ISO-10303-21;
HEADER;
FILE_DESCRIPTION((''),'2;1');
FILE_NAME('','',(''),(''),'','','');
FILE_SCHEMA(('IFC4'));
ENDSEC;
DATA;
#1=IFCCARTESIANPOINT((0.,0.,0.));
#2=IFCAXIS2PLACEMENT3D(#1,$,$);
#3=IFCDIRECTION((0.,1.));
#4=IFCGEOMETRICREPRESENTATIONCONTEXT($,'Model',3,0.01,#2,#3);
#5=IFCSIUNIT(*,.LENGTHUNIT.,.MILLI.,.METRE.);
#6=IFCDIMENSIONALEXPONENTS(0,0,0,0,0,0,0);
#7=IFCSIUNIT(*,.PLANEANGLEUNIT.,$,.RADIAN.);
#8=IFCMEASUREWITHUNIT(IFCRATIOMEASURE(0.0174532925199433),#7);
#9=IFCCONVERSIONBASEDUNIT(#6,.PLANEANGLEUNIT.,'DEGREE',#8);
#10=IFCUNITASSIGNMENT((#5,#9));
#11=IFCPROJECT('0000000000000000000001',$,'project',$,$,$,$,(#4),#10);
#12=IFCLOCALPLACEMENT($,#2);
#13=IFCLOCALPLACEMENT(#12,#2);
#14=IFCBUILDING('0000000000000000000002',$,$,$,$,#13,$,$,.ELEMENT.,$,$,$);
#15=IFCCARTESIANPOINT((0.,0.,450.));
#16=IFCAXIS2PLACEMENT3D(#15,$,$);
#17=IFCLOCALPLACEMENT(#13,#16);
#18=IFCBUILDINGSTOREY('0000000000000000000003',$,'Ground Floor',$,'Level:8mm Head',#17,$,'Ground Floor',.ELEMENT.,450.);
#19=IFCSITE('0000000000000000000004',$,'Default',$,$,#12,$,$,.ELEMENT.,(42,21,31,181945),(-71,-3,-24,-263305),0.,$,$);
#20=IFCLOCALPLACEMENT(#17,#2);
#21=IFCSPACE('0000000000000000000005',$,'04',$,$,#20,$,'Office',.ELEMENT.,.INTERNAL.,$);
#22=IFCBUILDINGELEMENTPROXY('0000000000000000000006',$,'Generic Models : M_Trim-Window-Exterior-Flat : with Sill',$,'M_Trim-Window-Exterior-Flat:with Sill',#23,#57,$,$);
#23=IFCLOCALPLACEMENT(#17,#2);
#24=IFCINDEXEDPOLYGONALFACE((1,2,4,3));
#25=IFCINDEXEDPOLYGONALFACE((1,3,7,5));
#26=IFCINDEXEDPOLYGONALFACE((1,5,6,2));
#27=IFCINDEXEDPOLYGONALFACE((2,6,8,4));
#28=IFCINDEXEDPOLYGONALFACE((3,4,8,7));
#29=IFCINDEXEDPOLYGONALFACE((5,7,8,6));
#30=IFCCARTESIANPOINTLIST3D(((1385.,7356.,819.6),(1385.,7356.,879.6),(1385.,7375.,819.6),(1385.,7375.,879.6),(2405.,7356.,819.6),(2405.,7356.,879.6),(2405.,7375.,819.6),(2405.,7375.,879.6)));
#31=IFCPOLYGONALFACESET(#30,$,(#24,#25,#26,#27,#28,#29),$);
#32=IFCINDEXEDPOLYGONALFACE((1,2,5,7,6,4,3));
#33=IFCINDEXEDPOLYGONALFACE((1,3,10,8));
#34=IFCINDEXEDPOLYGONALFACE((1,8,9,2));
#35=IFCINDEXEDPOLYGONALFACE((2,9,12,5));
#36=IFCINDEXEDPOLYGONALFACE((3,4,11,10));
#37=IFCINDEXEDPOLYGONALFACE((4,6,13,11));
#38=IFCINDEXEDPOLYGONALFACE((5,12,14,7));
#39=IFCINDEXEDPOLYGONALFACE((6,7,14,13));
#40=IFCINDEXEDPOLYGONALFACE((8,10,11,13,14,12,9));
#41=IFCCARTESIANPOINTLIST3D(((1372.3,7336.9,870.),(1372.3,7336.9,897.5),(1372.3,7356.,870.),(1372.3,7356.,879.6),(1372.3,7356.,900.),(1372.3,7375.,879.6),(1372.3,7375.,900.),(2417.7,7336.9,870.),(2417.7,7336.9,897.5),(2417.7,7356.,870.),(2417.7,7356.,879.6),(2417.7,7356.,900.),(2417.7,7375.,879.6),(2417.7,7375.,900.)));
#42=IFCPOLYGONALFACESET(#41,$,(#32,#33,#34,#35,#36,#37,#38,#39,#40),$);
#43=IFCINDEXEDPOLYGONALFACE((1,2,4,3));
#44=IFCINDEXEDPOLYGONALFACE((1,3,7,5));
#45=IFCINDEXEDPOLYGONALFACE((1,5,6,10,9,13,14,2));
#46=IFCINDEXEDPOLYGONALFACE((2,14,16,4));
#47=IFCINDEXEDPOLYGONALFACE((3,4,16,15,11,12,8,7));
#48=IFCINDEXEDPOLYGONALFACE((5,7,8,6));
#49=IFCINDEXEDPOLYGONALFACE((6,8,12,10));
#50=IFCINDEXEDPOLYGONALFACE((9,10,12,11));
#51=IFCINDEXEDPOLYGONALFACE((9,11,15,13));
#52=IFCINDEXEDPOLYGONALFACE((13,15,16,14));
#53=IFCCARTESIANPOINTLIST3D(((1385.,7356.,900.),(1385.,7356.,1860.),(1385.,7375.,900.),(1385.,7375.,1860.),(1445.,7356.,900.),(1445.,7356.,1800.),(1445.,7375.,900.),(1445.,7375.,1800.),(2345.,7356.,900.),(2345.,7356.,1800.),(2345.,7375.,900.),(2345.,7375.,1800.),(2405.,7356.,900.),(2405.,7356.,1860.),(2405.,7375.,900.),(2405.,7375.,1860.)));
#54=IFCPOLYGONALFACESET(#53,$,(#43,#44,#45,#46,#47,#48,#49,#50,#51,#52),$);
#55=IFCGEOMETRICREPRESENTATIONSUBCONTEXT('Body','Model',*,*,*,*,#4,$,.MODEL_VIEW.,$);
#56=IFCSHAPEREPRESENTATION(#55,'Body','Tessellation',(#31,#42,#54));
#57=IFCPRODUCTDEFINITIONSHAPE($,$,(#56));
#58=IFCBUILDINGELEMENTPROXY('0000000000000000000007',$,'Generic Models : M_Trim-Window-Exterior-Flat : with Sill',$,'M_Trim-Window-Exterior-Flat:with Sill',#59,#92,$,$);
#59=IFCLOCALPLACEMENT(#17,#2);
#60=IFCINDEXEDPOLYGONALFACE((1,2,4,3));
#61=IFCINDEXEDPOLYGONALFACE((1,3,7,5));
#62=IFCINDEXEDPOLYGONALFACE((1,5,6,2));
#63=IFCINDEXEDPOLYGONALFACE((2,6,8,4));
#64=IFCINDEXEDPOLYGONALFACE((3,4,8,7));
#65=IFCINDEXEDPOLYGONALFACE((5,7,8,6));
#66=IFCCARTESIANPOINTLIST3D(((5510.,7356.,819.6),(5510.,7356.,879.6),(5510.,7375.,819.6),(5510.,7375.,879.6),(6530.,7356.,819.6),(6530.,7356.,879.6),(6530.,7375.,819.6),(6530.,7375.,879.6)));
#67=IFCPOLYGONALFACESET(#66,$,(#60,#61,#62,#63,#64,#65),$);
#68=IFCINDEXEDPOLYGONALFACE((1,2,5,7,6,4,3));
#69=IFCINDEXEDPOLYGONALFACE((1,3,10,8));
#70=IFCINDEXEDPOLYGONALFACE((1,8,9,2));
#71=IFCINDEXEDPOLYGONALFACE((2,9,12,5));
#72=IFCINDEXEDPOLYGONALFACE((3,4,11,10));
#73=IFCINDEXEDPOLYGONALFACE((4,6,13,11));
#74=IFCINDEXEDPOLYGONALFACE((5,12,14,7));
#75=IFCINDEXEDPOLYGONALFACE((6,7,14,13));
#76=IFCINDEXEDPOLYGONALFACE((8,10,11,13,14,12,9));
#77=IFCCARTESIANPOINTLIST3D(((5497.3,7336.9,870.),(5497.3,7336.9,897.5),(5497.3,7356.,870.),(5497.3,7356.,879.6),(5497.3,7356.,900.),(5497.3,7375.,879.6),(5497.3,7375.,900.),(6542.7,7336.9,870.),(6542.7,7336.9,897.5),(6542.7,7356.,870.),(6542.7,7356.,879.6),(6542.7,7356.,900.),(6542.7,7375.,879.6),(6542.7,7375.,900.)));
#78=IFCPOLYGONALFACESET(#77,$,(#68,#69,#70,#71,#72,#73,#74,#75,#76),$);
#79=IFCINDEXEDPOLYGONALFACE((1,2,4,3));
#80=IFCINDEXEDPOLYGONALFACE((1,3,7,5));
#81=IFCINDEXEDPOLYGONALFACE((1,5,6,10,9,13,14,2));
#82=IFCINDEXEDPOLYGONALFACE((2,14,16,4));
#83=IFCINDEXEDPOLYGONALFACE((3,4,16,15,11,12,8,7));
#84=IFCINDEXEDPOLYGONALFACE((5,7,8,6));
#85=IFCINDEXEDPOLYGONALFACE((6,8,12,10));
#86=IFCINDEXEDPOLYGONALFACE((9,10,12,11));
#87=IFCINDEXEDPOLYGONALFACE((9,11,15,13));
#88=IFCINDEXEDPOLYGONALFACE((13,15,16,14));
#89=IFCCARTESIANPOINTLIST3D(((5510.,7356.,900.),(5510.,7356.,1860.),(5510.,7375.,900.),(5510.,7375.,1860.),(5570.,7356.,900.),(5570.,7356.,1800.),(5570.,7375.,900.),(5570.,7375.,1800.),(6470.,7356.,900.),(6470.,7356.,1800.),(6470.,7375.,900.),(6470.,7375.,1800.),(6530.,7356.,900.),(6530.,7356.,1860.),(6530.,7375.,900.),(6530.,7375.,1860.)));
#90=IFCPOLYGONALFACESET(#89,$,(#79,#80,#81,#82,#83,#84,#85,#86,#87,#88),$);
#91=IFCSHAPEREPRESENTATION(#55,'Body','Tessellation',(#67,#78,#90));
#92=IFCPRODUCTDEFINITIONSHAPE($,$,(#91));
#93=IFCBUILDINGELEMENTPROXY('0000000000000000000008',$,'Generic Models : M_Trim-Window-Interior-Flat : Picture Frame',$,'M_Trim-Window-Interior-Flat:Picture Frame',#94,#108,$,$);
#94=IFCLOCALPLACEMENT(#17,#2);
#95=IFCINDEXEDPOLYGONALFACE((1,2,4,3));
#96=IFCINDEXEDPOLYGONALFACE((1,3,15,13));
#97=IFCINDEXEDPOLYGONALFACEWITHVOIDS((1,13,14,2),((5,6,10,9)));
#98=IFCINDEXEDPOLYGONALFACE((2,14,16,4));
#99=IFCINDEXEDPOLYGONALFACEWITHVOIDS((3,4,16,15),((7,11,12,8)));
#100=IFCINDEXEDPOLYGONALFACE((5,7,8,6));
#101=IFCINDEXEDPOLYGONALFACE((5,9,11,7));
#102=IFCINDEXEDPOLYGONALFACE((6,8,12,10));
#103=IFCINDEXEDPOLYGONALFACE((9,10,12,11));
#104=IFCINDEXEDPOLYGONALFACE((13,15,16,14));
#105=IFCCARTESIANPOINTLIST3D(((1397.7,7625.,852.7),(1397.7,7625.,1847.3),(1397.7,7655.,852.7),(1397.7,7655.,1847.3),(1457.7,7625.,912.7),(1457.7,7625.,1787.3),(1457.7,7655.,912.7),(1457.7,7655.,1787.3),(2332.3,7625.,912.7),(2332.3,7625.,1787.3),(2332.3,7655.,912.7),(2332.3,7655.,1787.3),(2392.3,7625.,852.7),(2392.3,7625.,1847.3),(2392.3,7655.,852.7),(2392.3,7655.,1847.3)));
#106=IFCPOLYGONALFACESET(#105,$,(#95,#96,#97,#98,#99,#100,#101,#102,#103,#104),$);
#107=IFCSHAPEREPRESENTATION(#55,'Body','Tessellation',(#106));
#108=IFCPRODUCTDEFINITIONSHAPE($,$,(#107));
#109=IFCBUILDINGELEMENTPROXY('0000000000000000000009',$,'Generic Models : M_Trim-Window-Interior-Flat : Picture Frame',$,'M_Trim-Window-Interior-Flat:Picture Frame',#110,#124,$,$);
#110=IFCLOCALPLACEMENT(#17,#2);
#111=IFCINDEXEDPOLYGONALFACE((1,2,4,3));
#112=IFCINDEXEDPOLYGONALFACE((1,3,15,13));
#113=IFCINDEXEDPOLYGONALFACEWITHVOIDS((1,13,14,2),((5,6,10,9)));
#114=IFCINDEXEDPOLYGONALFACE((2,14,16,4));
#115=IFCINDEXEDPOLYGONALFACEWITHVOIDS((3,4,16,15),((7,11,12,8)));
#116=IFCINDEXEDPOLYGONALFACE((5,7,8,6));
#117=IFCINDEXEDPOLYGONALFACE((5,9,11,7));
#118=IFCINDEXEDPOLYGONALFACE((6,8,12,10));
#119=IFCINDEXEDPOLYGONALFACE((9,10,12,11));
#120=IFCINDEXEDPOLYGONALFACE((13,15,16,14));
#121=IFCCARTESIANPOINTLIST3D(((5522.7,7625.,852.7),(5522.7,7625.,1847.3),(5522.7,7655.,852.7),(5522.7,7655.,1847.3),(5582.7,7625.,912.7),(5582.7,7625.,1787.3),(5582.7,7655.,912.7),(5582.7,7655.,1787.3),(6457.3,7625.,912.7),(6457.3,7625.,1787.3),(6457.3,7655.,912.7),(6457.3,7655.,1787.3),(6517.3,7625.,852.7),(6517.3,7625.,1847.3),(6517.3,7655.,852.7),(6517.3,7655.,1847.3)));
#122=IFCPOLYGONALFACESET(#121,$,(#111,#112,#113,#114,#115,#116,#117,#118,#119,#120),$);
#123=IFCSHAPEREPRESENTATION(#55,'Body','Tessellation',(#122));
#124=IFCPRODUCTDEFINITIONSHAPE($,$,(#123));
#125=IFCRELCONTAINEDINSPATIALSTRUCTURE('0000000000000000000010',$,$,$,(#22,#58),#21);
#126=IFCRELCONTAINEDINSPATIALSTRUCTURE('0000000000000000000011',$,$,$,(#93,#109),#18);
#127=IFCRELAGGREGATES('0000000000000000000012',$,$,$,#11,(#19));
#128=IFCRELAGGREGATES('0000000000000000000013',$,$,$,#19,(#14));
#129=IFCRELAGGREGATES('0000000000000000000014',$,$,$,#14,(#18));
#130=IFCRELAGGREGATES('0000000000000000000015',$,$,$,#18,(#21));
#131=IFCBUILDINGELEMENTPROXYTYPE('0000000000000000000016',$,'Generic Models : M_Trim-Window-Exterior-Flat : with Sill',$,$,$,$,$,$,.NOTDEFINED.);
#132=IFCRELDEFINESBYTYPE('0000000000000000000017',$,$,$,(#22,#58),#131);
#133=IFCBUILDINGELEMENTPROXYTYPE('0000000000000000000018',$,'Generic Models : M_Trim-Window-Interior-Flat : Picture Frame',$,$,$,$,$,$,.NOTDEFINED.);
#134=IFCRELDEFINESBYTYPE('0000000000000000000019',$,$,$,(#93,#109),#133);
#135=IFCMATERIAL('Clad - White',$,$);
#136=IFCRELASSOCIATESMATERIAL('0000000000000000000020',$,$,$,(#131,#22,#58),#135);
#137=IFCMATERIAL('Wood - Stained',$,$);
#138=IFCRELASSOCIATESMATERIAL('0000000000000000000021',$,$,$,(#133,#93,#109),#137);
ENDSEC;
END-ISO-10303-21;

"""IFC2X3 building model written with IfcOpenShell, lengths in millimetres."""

from ifc_helpers import new_model, entity, si_unit, converted_unit, direction, frame, frame_2d, origin, place, context, subcontext, project, spatial, polyline, rectangle, outline, extrude, source, transform, mapped, material, type_object, type_shapes, element, save


model = new_model("IFC2X3")

# Units and contexts
model_context = context("Model", 3, precision=0.01, world=origin(), true_north=direction((0.0, 1.0)))
body_context = subcontext(model_context, "Body", "Model", "MODEL_VIEW")
ifc_project = project(units=[si_unit("LENGTHUNIT", "METRE", prefix="MILLI"), converted_unit("PLANEANGLEUNIT", "DEGREE", entity("IfcRatioMeasure", 0.0174532925199433), si_unit("PLANEANGLEUNIT", "RADIAN"), dimensions=[0, 0, 0, 0, 0, 0, 0])], contexts=[model_context])

# Site, building, storey
site_placement = place(None, origin())
site = spatial("IfcSite", under=ifc_project, at=site_placement, Name="Default", CompositionType="ELEMENT", RefLatitude=(42, 21, 31, 181945), RefLongitude=(-71, -3, -24, -263305), RefElevation=0.0)
building_placement = place(site_placement, origin())
building = spatial("IfcBuilding", under=site, at=building_placement, CompositionType="ELEMENT")
storey_placement = place(building_placement, frame((0.0, 0.0, 450.0)))
storey = spatial("IfcBuildingStorey", under=building, at=storey_placement, Name="Ground Floor", ObjectType="Level:8mm Head", LongName="Ground Floor", CompositionType="ELEMENT", Elevation=450.0)

# Shared definitions
ifc_material_1 = material(Name="Clad - White")
ifc_material_2 = material(Name="Wood - Stained")

# Shared definitions
space_placement = place(storey_placement, origin())
space = spatial("IfcSpace", under=storey, at=space_placement, Name="04", LongName="Office", CompositionType="ELEMENT", InteriorOrExteriorSpace="INTERNAL")

# Building element proxies
building_element_proxy_type_1 = type_object("IfcBuildingElementProxyType", Name="Generic Models : M_Trim-Window-Exterior-Flat : with Sill", PredefinedType="NOTDEFINED", material=ifc_material_1)
shared_shape_1 = source(origin(), body_context, "Body", "SweptSolid", [
    extrude(rectangle(XDim=1020.0, YDim=60.0, at=frame_2d((0.0, 0.0), x_axis=(1.0, 0.0))), frame((0.0, -950.4, 0.0), z_axis=(0.0, 0.0, 1.0), x_axis=(-1.0, 0.0, 0.0)), (0.0, 0.0, 1.0), 19.1),
    extrude(outline(polyline([(-19.0, -15.2), (0.0, -15.2), (0.0, -5.7), (19.0, -5.7), (19.0, 14.8), (0.0, 14.8), (-19.0, 12.3), (-19.0, -15.2)])), frame((-522.7, -914.8, 19.0), z_axis=(1.0, 0.0, 0.0), x_axis=(0.0, 0.0, -1.0)), (0.0, 0.0, 1.0), 1045.4),
    extrude(outline(polyline([(-495.0, -510.0), (465.0, -510.0), (465.0, -450.0), (-435.0, -450.0), (-435.0, 450.0), (465.0, 450.0), (465.0, 510.0), (-495.0, 510.0), (-495.0, -510.0)])), frame((0.0, -435.0, 0.0), z_axis=(0.0, 0.0, 1.0), x_axis=(0.0, -1.0, 0.0)), (0.0, 0.0, 1.0), 19.1),
])
type_shapes(building_element_proxy_type_1, [shared_shape_1])
for number, where, z_axis, x_axis, name in (
    (1, (1895.0, 7375.0, 1800.0), (0.0, -1.0, 0.0), (1.0, 0.0, 0.0), "Generic Models : M_Trim-Window-Exterior-Flat : with Sill"),
    (2, (6020.0, 7375.0, 1800.0), (0.0, -1.0, 0.0), (1.0, 0.0, 0.0), "Generic Models : M_Trim-Window-Exterior-Flat : with Sill"),
):
    element("IfcBuildingElementProxy", number, at=place(space_placement, frame(where, z_axis=z_axis, x_axis=x_axis)), inside=space, type_object=building_element_proxy_type_1, material=ifc_material_1, Name=name, ObjectType="M_Trim-Window-Exterior-Flat:with Sill", context=body_context, shape_type="MappedRepresentation", body=[
        mapped(shared_shape_1, transform((0.0, 0.0, 0.0), scale=1.0)),
    ])
building_element_proxy_type_2 = type_object("IfcBuildingElementProxyType", Name="Generic Models : M_Trim-Window-Interior-Flat : Picture Frame", PredefinedType="NOTDEFINED", material=ifc_material_2)
shared_shape_2 = source(origin(), body_context, "Body", "SweptSolid", [
    extrude(outline(polyline([(-497.3, -497.3), (497.3, -497.3), (497.3, 497.3), (-497.3, 497.3), (-497.3, -497.3)]), holes=[polyline([(-437.3, -437.3), (-437.3, 437.3), (437.3, 437.3), (437.3, -437.3), (-437.3, -437.3)])]), frame((0.0, -450.0, 0.0), z_axis=(0.0, 0.0, 1.0), x_axis=(-1.0, 0.0, 0.0)), (0.0, 0.0, 1.0), 30.0),
])
type_shapes(building_element_proxy_type_2, [shared_shape_2])
for number, where, z_axis, x_axis, name in (
    (3, (1895.0, 7625.0, 1800.0), (0.0, 1.0, 0.0), (-1.0, 0.0, 0.0), "Generic Models : M_Trim-Window-Interior-Flat : Picture Frame"),
    (4, (6020.0, 7625.0, 1800.0), (0.0, 1.0, 0.0), (-1.0, 0.0, 0.0), "Generic Models : M_Trim-Window-Interior-Flat : Picture Frame"),
):
    element("IfcBuildingElementProxy", number, at=place(storey_placement, frame(where, z_axis=z_axis, x_axis=x_axis)), inside=storey, type_object=building_element_proxy_type_2, material=ifc_material_2, Name=name, ObjectType="M_Trim-Window-Interior-Flat:Picture Frame", context=body_context, shape_type="MappedRepresentation", body=[
        mapped(shared_shape_2, transform((0.0, 0.0, 0.0), scale=1.0)),
    ])

save(model, "model.ifc")
